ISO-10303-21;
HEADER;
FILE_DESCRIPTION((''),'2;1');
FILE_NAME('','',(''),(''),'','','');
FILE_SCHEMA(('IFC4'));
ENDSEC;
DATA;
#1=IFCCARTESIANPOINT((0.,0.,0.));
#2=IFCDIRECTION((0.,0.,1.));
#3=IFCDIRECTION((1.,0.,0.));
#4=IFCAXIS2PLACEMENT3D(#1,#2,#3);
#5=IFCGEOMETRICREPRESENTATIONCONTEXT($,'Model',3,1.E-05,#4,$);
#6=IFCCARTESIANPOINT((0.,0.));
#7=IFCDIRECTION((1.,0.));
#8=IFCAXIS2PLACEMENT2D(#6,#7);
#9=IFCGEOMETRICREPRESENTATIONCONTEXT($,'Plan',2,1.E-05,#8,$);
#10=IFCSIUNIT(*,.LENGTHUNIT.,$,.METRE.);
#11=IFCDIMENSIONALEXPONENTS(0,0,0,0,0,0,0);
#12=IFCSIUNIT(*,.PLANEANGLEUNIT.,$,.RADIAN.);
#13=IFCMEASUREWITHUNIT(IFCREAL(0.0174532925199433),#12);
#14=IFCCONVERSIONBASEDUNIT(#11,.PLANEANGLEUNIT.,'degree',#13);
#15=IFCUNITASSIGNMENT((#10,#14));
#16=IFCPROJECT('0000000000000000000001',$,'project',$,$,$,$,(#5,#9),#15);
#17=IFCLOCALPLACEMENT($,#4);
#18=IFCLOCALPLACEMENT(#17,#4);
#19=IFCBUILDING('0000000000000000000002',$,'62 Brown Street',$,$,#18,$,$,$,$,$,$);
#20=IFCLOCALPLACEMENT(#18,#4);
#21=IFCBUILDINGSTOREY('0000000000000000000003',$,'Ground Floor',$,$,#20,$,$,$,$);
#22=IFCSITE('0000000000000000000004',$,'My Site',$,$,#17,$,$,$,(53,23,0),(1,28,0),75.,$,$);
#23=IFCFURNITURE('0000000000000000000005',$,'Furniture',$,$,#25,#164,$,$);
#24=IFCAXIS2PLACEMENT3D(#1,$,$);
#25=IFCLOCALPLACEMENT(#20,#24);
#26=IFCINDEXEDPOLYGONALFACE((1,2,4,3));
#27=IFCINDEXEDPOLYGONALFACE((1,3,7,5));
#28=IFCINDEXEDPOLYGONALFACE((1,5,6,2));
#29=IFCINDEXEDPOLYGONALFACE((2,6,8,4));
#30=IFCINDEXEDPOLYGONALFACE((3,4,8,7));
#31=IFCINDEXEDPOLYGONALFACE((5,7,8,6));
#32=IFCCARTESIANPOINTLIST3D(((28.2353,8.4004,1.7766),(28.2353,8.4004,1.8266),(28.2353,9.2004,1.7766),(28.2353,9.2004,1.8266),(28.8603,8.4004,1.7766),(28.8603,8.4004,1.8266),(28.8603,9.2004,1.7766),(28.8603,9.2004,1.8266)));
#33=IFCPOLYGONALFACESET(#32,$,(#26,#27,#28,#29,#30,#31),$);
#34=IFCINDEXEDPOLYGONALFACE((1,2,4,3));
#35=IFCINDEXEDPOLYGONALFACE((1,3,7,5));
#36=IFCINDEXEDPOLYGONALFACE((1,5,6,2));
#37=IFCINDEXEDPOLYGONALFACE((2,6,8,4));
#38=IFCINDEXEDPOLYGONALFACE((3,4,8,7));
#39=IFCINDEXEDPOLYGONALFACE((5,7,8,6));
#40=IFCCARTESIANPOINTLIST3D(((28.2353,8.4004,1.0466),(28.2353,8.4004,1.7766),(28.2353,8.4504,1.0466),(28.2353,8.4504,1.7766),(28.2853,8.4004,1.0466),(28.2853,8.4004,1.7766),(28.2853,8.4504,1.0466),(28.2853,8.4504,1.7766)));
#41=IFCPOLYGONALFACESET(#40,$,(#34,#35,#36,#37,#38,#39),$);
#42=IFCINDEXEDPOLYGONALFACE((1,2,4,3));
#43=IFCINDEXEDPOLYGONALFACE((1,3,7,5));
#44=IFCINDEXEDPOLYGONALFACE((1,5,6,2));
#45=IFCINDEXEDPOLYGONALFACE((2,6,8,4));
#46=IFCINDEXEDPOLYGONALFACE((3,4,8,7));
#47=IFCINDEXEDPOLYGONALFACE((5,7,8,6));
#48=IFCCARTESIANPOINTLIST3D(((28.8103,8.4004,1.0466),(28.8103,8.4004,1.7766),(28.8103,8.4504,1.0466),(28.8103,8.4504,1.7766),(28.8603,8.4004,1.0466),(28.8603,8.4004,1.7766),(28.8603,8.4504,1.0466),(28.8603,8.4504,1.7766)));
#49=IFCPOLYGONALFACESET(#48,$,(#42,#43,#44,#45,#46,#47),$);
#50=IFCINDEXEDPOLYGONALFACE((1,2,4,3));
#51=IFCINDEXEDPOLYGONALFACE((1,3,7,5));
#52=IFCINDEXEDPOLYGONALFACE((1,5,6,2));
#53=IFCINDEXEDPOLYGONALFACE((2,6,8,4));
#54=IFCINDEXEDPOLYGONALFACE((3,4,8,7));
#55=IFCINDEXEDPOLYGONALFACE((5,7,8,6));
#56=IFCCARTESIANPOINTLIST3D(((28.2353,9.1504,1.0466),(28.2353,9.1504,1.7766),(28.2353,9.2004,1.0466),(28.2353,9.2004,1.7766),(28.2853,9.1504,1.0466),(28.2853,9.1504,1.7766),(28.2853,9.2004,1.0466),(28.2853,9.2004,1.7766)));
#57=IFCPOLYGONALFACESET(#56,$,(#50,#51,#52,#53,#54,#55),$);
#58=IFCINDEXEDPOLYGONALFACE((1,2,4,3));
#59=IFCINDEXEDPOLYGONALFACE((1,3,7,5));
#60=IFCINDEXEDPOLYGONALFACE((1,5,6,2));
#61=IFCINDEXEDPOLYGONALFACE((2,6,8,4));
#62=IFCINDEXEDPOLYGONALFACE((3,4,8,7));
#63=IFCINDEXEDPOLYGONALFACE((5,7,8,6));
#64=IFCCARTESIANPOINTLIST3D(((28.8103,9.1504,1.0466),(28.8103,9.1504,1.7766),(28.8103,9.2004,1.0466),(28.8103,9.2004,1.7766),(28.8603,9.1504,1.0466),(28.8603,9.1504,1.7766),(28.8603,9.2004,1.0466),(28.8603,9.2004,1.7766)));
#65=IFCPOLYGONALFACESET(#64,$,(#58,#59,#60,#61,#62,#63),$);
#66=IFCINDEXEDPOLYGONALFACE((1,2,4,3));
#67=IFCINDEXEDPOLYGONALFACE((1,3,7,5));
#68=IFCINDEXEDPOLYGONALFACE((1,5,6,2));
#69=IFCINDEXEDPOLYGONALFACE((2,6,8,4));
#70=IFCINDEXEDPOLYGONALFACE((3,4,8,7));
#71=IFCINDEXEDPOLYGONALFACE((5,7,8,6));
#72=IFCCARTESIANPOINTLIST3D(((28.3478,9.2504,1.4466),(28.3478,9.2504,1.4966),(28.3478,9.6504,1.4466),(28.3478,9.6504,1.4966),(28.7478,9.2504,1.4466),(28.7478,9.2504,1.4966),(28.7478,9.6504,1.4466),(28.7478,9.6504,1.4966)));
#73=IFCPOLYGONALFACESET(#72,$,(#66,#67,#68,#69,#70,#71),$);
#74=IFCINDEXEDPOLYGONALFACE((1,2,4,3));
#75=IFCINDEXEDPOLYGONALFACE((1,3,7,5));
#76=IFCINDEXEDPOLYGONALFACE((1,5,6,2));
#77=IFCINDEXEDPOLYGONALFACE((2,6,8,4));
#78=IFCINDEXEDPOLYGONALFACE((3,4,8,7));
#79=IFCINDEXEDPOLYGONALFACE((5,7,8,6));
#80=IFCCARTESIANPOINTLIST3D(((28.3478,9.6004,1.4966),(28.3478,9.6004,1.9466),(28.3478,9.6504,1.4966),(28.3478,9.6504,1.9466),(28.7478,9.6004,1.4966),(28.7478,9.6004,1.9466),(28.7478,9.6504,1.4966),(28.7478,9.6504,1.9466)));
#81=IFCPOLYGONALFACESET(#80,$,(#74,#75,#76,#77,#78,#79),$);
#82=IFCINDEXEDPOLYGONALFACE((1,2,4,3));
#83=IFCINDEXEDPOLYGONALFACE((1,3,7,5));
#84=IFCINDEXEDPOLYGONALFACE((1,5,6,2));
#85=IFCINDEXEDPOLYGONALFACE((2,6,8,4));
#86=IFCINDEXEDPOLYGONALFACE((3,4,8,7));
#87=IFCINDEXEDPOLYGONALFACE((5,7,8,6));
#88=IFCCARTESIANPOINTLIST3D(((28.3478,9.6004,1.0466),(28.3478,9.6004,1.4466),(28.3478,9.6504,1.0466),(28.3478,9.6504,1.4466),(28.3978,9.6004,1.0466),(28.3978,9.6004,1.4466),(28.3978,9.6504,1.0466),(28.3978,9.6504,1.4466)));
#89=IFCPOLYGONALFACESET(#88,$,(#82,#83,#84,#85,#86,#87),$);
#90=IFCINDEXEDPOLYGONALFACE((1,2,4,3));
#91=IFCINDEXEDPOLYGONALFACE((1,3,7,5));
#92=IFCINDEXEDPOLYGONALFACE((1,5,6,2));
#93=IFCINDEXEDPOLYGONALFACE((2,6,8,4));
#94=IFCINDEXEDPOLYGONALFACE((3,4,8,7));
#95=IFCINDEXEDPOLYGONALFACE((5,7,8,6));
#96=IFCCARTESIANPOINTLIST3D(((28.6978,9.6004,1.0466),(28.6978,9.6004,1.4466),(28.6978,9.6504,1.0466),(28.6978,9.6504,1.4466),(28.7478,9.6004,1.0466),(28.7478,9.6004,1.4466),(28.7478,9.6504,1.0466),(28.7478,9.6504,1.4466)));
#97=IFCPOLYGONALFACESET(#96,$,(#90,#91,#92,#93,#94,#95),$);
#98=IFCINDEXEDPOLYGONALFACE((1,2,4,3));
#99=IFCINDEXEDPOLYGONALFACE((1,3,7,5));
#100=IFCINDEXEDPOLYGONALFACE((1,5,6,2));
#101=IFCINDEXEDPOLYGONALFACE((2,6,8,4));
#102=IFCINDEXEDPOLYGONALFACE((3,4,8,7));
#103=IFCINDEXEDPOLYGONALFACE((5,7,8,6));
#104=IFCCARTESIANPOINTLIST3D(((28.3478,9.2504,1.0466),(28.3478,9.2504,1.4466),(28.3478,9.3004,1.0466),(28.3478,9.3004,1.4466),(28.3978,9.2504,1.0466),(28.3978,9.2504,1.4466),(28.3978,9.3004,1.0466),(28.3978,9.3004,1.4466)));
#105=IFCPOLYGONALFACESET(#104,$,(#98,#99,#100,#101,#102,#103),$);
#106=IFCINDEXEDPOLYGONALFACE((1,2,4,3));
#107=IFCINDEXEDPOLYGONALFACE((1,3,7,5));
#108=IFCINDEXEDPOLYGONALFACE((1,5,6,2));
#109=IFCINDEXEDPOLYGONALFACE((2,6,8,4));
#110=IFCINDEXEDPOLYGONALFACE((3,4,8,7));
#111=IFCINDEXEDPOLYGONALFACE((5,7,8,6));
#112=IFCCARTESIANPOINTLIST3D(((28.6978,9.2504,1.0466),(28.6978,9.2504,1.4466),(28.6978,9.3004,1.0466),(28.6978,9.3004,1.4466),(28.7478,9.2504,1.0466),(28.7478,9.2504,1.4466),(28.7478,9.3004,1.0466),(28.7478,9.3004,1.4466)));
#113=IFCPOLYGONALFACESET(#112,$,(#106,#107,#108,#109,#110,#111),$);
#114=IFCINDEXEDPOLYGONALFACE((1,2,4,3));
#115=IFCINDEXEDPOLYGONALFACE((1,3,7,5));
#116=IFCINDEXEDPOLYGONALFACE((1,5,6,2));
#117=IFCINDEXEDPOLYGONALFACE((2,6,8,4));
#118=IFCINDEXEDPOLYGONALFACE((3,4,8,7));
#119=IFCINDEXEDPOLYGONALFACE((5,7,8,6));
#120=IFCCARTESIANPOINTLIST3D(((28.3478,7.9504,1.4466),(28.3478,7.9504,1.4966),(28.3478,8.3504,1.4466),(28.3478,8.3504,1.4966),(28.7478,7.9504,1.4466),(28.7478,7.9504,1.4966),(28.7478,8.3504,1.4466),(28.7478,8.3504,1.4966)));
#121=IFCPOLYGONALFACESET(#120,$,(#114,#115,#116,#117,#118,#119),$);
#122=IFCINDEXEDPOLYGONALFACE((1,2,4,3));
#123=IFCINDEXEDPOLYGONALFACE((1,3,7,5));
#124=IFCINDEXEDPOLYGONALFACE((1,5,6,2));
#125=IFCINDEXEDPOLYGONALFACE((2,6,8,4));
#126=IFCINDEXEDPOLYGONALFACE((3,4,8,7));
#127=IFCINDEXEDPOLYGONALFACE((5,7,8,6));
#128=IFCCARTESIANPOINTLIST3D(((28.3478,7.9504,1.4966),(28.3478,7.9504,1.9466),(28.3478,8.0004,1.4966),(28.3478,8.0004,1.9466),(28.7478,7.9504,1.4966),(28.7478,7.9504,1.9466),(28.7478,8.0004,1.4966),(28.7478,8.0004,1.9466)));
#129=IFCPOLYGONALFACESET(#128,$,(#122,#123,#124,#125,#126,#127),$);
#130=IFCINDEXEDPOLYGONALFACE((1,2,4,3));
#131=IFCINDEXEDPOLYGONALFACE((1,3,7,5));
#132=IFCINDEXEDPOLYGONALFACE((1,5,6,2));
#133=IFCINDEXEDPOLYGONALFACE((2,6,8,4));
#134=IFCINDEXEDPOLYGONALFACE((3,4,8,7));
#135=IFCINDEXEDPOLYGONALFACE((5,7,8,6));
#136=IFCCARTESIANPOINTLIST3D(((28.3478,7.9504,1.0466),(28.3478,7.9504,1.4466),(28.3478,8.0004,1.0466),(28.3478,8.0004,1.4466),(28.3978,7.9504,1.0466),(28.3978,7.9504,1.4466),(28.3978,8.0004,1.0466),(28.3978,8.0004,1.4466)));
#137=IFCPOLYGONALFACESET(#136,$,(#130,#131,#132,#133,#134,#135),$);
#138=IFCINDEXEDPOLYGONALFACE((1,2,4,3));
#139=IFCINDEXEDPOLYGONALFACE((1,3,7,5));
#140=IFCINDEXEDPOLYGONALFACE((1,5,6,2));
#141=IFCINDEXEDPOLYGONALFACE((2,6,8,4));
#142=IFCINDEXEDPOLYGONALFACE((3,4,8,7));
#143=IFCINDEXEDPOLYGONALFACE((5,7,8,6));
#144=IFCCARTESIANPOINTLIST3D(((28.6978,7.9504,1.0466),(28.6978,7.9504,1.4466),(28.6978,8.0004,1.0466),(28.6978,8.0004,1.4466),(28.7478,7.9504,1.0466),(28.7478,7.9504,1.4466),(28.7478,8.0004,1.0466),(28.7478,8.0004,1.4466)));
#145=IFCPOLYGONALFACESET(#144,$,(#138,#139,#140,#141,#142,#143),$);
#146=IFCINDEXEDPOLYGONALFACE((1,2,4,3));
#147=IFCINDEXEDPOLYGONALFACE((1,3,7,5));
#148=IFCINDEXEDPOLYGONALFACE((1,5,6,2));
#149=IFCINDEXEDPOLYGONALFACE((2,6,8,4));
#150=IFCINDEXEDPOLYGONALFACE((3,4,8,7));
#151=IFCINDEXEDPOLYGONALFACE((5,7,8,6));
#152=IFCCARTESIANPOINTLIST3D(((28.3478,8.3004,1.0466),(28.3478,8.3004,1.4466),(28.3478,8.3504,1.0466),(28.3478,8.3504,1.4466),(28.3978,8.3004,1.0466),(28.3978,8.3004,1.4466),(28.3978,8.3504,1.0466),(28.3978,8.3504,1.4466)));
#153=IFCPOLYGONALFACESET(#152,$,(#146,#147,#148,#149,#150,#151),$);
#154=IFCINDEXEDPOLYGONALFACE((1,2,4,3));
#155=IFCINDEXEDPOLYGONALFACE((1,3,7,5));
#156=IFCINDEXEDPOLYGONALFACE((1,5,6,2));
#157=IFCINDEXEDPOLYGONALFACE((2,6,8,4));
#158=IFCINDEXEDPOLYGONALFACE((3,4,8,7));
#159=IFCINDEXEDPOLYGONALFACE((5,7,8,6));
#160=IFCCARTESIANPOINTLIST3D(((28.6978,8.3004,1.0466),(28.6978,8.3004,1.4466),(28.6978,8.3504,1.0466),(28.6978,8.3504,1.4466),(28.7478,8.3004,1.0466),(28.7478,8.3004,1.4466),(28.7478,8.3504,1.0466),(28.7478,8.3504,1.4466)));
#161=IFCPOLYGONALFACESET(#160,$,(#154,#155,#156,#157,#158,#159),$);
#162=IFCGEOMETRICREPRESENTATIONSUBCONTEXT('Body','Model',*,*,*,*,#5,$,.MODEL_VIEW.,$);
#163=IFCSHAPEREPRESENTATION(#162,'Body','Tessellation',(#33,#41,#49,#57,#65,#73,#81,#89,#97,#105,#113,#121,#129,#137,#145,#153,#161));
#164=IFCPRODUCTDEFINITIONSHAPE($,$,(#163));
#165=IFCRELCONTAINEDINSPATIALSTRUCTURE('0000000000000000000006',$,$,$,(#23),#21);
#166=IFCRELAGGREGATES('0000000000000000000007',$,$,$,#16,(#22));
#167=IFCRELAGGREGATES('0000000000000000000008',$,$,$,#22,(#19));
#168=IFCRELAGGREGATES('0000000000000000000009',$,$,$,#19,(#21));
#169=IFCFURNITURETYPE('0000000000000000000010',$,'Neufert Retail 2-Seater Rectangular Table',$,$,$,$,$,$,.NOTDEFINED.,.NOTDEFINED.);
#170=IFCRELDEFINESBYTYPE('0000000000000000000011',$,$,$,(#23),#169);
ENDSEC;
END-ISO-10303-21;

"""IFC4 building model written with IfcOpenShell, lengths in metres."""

from ifc_helpers import new_model, entity, si_unit, converted_unit, frame, origin_with_axes, origin_2d_with_axis, place, context, subcontext, project, spatial, line, indexed_curve, outline, extrude, shape, source, transform, mapped, type_object, type_shapes, element, save


model = new_model("IFC4")

# Units and contexts
model_context = context("Model", 3, precision=1e-05, world=origin_with_axes())
plan_context = context("Plan", 2, precision=1e-05, world=origin_2d_with_axis())
body_context_1 = subcontext(model_context, "Body", "Model", "MODEL_VIEW")
body_context_2 = subcontext(plan_context, "Body", "Plan", "PLAN_VIEW")
ifc_project = project(units=[si_unit("LENGTHUNIT", "METRE"), converted_unit("PLANEANGLEUNIT", "degree", entity("IfcReal", 0.0174532925199433), si_unit("PLANEANGLEUNIT", "RADIAN"), dimensions=[0, 0, 0, 0, 0, 0, 0])], contexts=[model_context, plan_context])

# Site, building, storey
site_placement = place(None, origin_with_axes())
site = spatial("IfcSite", under=ifc_project, at=site_placement, Name="My Site", RefLatitude=(53, 23, 0), RefLongitude=(1, 28, 0), RefElevation=75.0)
building_placement = place(site_placement, origin_with_axes())
building = spatial("IfcBuilding", under=site, at=building_placement, Name="62 Brown Street")
storey_placement = place(building_placement, origin_with_axes())
storey = spatial("IfcBuildingStorey", under=building, at=storey_placement, Name="Ground Floor")

# Furniture
furniture_type_1 = type_object("IfcFurnitureType", Name="Neufert Retail 2-Seater Rectangular Table", AssemblyPlace="NOTDEFINED", PredefinedType="NOTDEFINED")
shared_shape_1 = source(origin_with_axes(), body_context_1, "Body", "SweptSolid", [
    extrude(outline(indexed_curve([(0.0, 0.0), (0.625, 0.0), (0.625, 0.8), (0.0, 0.8)], segments=[line(1, 2, 3, 4, 1)])), frame((-0.3125, -0.4, 0.73), z_axis=(0.0, 0.0, 1.0), x_axis=(1.0, 0.0, 0.0)), (0.0, 0.0, 1.0), 0.05),
    extrude(outline(indexed_curve([(0.0, 0.0), (0.05, 0.0), (0.05, 0.05), (0.0, 0.05)], segments=[line(1, 2, 3, 4, 1)])), frame((-0.3125, -0.4, 0.0), z_axis=(0.0, 0.0, 1.0), x_axis=(1.0, 0.0, 0.0)), (0.0, 0.0, 1.0), 0.73),
    extrude(outline(indexed_curve([(0.625, 0.0), (0.575, 0.0), (0.575, 0.05), (0.625, 0.05)], segments=[line(1, 2, 3, 4, 1)])), frame((-0.3125, -0.4, 0.0), z_axis=(0.0, 0.0, 1.0), x_axis=(1.0, 0.0, 0.0)), (0.0, 0.0, 1.0), 0.73),
    extrude(outline(indexed_curve([(0.0, 0.8), (0.05, 0.8), (0.05, 0.75), (0.0, 0.75)], segments=[line(1, 2, 3, 4, 1)])), frame((-0.3125, -0.4, 0.0), z_axis=(0.0, 0.0, 1.0), x_axis=(1.0, 0.0, 0.0)), (0.0, 0.0, 1.0), 0.73),
    extrude(outline(indexed_curve([(0.625, 0.8), (0.575, 0.8), (0.575, 0.75), (0.625, 0.75)], segments=[line(1, 2, 3, 4, 1)])), frame((-0.3125, -0.4, 0.0), z_axis=(0.0, 0.0, 1.0), x_axis=(1.0, 0.0, 0.0)), (0.0, 0.0, 1.0), 0.73),
    extrude(outline(indexed_curve([(-0.2, 0.0), (0.2, 0.0), (0.2, -0.4), (-0.2, -0.4)], segments=[line(1, 2, 3, 4, 1)])), frame((0.0, 0.85, 0.45), z_axis=(0.0, 0.0, 1.0), x_axis=(1.0, 0.0, 0.0)), (0.0, 0.0, -1.0), 0.05),
    extrude(outline(indexed_curve([(-0.2, 0.0), (0.2, 0.0), (0.2, -0.05), (-0.2, -0.05)], segments=[line(1, 2, 3, 4, 1)])), frame((0.0, 0.85, 0.9), z_axis=(0.0, 0.0, 1.0), x_axis=(1.0, 0.0, 0.0)), (0.0, 0.0, -1.0), 0.45),
    extrude(outline(indexed_curve([(-0.2, 0.0), (-0.15, 0.0), (-0.15, -0.05), (-0.2, -0.05)], segments=[line(1, 2, 3, 4, 1)])), frame((0.0, 0.85, 0.0), z_axis=(0.0, 0.0, 1.0), x_axis=(1.0, 0.0, 0.0)), (0.0, 0.0, 1.0), 0.4),
    extrude(outline(indexed_curve([(0.2, 0.0), (0.15, 0.0), (0.15, -0.05), (0.2, -0.05)], segments=[line(1, 2, 3, 4, 1)])), frame((0.0, 0.85, 0.0), z_axis=(0.0, 0.0, 1.0), x_axis=(1.0, 0.0, 0.0)), (0.0, 0.0, 1.0), 0.4),
    extrude(outline(indexed_curve([(-0.2, -0.4), (-0.15, -0.4), (-0.15, -0.35), (-0.2, -0.35)], segments=[line(1, 2, 3, 4, 1)])), frame((0.0, 0.85, 0.0), z_axis=(0.0, 0.0, 1.0), x_axis=(1.0, 0.0, 0.0)), (0.0, 0.0, 1.0), 0.4),
    extrude(outline(indexed_curve([(0.2, -0.4), (0.15, -0.4), (0.15, -0.35), (0.2, -0.35)], segments=[line(1, 2, 3, 4, 1)])), frame((0.0, 0.85, 0.0), z_axis=(0.0, 0.0, 1.0), x_axis=(1.0, 0.0, 0.0)), (0.0, 0.0, 1.0), 0.4),
    extrude(outline(indexed_curve([(-0.2, 0.0), (0.2, 0.0), (0.2, 0.4), (-0.2, 0.4)], segments=[line(1, 2, 3, 4, 1)])), frame((0.0, -0.85, 0.45), z_axis=(0.0, 0.0, 1.0), x_axis=(1.0, 0.0, 0.0)), (0.0, 0.0, -1.0), 0.05),
    extrude(outline(indexed_curve([(-0.2, 0.0), (0.2, 0.0), (0.2, 0.05), (-0.2, 0.05)], segments=[line(1, 2, 3, 4, 1)])), frame((0.0, -0.85, 0.9), z_axis=(0.0, 0.0, 1.0), x_axis=(1.0, 0.0, 0.0)), (0.0, 0.0, -1.0), 0.45),
    extrude(outline(indexed_curve([(-0.2, 0.0), (-0.15, 0.0), (-0.15, 0.05), (-0.2, 0.05)], segments=[line(1, 2, 3, 4, 1)])), frame((0.0, -0.85, 0.0), z_axis=(0.0, 0.0, 1.0), x_axis=(1.0, 0.0, 0.0)), (0.0, 0.0, 1.0), 0.4),
    extrude(outline(indexed_curve([(0.2, 0.0), (0.15, 0.0), (0.15, 0.05), (0.2, 0.05)], segments=[line(1, 2, 3, 4, 1)])), frame((0.0, -0.85, 0.0), z_axis=(0.0, 0.0, 1.0), x_axis=(1.0, 0.0, 0.0)), (0.0, 0.0, 1.0), 0.4),
    extrude(outline(indexed_curve([(-0.2, 0.4), (-0.15, 0.4), (-0.15, 0.35), (-0.2, 0.35)], segments=[line(1, 2, 3, 4, 1)])), frame((0.0, -0.85, 0.0), z_axis=(0.0, 0.0, 1.0), x_axis=(1.0, 0.0, 0.0)), (0.0, 0.0, 1.0), 0.4),
    extrude(outline(indexed_curve([(0.2, 0.4), (0.15, 0.4), (0.15, 0.35), (0.2, 0.35)], segments=[line(1, 2, 3, 4, 1)])), frame((0.0, -0.85, 0.0), z_axis=(0.0, 0.0, 1.0), x_axis=(1.0, 0.0, 0.0)), (0.0, 0.0, 1.0), 0.4),
])
shared_shape_2 = source(origin_with_axes(), body_context_2, "Body", "Curve2D", [
    entity("IfcIndexedPolyCurve", entity("IfcCartesianPointList2D", [[-0.3125, -0.4], [0.3125, -0.4], [0.3125, 0.4], [-0.3125, 0.4]]), [entity("IfcLineIndex", [1, 2, 3, 4, 1])]),
    entity("IfcIndexedPolyCurve", entity("IfcCartesianPointList2D", [[-0.2, 0.45], [0.2, 0.45]])),
    entity("IfcIndexedPolyCurve", entity("IfcCartesianPointList2D", [[-0.2, 0.45], [-0.2, 0.65], [-0.1414, 0.7914], [0.0, 0.85], [0.1414, 0.7914], [0.2, 0.65], [0.2, 0.45]]), [entity("IfcLineIndex", [1, 2]), entity("IfcArcIndex", [2, 3, 4]), entity("IfcArcIndex", [4, 5, 6]), entity("IfcLineIndex", [6, 7])]),
    entity("IfcIndexedPolyCurve", entity("IfcCartesianPointList2D", [[-0.16, 0.45], [-0.16, 0.65], [-0.1131, 0.7631], [0.0, 0.81], [0.1131, 0.7631], [0.16, 0.65], [0.16, 0.45]]), [entity("IfcLineIndex", [1, 2]), entity("IfcArcIndex", [2, 3, 4]), entity("IfcArcIndex", [4, 5, 6]), entity("IfcLineIndex", [6, 7])]),
    entity("IfcIndexedPolyCurve", entity("IfcCartesianPointList2D", [[-0.2, -0.45], [0.2, -0.45]])),
    entity("IfcIndexedPolyCurve", entity("IfcCartesianPointList2D", [[-0.2, -0.45], [-0.2, -0.65], [-0.1414, -0.7914], [0.0, -0.85], [0.1414, -0.7914], [0.2, -0.65], [0.2, -0.45]]), [entity("IfcLineIndex", [1, 2]), entity("IfcArcIndex", [2, 3, 4]), entity("IfcArcIndex", [4, 5, 6]), entity("IfcLineIndex", [6, 7])]),
    entity("IfcIndexedPolyCurve", entity("IfcCartesianPointList2D", [[-0.16, -0.45], [-0.16, -0.65], [-0.1131, -0.7631], [0.0, -0.81], [0.1131, -0.7631], [0.16, -0.65], [0.16, -0.45]]), [entity("IfcLineIndex", [1, 2]), entity("IfcArcIndex", [2, 3, 4]), entity("IfcArcIndex", [4, 5, 6]), entity("IfcLineIndex", [6, 7])]),
])
type_shapes(furniture_type_1, [shared_shape_1, shared_shape_2])
furniture_placement = place(storey_placement, frame((28.5478, 8.8004, 1.0466), z_axis=(0.0, 0.0, 1.0), x_axis=(1.0, 0.0, 0.0)))
element("IfcFurniture", 1, at=furniture_placement, inside=storey, type_object=furniture_type_1, Name="Furniture", shapes=[
    shape(body_context_1, "Body", "MappedRepresentation", [mapped(shared_shape_1, transform((0.0, 0.0, 0.0), x_axis=(1.0, 0.0, 0.0), y_axis=(0.0, 1.0, 0.0), z_axis=(0.0, 0.0, 1.0), scale=1.0))]),
    shape(body_context_2, "Body", "MappedRepresentation", [mapped(shared_shape_2, transform((0.0, 0.0, 0.0), x_axis=(1.0, 0.0, 0.0), y_axis=(0.0, 1.0, 0.0), z_axis=(0.0, 0.0, 1.0), scale=1.0))]),
])

save(model, "model.ifc")
